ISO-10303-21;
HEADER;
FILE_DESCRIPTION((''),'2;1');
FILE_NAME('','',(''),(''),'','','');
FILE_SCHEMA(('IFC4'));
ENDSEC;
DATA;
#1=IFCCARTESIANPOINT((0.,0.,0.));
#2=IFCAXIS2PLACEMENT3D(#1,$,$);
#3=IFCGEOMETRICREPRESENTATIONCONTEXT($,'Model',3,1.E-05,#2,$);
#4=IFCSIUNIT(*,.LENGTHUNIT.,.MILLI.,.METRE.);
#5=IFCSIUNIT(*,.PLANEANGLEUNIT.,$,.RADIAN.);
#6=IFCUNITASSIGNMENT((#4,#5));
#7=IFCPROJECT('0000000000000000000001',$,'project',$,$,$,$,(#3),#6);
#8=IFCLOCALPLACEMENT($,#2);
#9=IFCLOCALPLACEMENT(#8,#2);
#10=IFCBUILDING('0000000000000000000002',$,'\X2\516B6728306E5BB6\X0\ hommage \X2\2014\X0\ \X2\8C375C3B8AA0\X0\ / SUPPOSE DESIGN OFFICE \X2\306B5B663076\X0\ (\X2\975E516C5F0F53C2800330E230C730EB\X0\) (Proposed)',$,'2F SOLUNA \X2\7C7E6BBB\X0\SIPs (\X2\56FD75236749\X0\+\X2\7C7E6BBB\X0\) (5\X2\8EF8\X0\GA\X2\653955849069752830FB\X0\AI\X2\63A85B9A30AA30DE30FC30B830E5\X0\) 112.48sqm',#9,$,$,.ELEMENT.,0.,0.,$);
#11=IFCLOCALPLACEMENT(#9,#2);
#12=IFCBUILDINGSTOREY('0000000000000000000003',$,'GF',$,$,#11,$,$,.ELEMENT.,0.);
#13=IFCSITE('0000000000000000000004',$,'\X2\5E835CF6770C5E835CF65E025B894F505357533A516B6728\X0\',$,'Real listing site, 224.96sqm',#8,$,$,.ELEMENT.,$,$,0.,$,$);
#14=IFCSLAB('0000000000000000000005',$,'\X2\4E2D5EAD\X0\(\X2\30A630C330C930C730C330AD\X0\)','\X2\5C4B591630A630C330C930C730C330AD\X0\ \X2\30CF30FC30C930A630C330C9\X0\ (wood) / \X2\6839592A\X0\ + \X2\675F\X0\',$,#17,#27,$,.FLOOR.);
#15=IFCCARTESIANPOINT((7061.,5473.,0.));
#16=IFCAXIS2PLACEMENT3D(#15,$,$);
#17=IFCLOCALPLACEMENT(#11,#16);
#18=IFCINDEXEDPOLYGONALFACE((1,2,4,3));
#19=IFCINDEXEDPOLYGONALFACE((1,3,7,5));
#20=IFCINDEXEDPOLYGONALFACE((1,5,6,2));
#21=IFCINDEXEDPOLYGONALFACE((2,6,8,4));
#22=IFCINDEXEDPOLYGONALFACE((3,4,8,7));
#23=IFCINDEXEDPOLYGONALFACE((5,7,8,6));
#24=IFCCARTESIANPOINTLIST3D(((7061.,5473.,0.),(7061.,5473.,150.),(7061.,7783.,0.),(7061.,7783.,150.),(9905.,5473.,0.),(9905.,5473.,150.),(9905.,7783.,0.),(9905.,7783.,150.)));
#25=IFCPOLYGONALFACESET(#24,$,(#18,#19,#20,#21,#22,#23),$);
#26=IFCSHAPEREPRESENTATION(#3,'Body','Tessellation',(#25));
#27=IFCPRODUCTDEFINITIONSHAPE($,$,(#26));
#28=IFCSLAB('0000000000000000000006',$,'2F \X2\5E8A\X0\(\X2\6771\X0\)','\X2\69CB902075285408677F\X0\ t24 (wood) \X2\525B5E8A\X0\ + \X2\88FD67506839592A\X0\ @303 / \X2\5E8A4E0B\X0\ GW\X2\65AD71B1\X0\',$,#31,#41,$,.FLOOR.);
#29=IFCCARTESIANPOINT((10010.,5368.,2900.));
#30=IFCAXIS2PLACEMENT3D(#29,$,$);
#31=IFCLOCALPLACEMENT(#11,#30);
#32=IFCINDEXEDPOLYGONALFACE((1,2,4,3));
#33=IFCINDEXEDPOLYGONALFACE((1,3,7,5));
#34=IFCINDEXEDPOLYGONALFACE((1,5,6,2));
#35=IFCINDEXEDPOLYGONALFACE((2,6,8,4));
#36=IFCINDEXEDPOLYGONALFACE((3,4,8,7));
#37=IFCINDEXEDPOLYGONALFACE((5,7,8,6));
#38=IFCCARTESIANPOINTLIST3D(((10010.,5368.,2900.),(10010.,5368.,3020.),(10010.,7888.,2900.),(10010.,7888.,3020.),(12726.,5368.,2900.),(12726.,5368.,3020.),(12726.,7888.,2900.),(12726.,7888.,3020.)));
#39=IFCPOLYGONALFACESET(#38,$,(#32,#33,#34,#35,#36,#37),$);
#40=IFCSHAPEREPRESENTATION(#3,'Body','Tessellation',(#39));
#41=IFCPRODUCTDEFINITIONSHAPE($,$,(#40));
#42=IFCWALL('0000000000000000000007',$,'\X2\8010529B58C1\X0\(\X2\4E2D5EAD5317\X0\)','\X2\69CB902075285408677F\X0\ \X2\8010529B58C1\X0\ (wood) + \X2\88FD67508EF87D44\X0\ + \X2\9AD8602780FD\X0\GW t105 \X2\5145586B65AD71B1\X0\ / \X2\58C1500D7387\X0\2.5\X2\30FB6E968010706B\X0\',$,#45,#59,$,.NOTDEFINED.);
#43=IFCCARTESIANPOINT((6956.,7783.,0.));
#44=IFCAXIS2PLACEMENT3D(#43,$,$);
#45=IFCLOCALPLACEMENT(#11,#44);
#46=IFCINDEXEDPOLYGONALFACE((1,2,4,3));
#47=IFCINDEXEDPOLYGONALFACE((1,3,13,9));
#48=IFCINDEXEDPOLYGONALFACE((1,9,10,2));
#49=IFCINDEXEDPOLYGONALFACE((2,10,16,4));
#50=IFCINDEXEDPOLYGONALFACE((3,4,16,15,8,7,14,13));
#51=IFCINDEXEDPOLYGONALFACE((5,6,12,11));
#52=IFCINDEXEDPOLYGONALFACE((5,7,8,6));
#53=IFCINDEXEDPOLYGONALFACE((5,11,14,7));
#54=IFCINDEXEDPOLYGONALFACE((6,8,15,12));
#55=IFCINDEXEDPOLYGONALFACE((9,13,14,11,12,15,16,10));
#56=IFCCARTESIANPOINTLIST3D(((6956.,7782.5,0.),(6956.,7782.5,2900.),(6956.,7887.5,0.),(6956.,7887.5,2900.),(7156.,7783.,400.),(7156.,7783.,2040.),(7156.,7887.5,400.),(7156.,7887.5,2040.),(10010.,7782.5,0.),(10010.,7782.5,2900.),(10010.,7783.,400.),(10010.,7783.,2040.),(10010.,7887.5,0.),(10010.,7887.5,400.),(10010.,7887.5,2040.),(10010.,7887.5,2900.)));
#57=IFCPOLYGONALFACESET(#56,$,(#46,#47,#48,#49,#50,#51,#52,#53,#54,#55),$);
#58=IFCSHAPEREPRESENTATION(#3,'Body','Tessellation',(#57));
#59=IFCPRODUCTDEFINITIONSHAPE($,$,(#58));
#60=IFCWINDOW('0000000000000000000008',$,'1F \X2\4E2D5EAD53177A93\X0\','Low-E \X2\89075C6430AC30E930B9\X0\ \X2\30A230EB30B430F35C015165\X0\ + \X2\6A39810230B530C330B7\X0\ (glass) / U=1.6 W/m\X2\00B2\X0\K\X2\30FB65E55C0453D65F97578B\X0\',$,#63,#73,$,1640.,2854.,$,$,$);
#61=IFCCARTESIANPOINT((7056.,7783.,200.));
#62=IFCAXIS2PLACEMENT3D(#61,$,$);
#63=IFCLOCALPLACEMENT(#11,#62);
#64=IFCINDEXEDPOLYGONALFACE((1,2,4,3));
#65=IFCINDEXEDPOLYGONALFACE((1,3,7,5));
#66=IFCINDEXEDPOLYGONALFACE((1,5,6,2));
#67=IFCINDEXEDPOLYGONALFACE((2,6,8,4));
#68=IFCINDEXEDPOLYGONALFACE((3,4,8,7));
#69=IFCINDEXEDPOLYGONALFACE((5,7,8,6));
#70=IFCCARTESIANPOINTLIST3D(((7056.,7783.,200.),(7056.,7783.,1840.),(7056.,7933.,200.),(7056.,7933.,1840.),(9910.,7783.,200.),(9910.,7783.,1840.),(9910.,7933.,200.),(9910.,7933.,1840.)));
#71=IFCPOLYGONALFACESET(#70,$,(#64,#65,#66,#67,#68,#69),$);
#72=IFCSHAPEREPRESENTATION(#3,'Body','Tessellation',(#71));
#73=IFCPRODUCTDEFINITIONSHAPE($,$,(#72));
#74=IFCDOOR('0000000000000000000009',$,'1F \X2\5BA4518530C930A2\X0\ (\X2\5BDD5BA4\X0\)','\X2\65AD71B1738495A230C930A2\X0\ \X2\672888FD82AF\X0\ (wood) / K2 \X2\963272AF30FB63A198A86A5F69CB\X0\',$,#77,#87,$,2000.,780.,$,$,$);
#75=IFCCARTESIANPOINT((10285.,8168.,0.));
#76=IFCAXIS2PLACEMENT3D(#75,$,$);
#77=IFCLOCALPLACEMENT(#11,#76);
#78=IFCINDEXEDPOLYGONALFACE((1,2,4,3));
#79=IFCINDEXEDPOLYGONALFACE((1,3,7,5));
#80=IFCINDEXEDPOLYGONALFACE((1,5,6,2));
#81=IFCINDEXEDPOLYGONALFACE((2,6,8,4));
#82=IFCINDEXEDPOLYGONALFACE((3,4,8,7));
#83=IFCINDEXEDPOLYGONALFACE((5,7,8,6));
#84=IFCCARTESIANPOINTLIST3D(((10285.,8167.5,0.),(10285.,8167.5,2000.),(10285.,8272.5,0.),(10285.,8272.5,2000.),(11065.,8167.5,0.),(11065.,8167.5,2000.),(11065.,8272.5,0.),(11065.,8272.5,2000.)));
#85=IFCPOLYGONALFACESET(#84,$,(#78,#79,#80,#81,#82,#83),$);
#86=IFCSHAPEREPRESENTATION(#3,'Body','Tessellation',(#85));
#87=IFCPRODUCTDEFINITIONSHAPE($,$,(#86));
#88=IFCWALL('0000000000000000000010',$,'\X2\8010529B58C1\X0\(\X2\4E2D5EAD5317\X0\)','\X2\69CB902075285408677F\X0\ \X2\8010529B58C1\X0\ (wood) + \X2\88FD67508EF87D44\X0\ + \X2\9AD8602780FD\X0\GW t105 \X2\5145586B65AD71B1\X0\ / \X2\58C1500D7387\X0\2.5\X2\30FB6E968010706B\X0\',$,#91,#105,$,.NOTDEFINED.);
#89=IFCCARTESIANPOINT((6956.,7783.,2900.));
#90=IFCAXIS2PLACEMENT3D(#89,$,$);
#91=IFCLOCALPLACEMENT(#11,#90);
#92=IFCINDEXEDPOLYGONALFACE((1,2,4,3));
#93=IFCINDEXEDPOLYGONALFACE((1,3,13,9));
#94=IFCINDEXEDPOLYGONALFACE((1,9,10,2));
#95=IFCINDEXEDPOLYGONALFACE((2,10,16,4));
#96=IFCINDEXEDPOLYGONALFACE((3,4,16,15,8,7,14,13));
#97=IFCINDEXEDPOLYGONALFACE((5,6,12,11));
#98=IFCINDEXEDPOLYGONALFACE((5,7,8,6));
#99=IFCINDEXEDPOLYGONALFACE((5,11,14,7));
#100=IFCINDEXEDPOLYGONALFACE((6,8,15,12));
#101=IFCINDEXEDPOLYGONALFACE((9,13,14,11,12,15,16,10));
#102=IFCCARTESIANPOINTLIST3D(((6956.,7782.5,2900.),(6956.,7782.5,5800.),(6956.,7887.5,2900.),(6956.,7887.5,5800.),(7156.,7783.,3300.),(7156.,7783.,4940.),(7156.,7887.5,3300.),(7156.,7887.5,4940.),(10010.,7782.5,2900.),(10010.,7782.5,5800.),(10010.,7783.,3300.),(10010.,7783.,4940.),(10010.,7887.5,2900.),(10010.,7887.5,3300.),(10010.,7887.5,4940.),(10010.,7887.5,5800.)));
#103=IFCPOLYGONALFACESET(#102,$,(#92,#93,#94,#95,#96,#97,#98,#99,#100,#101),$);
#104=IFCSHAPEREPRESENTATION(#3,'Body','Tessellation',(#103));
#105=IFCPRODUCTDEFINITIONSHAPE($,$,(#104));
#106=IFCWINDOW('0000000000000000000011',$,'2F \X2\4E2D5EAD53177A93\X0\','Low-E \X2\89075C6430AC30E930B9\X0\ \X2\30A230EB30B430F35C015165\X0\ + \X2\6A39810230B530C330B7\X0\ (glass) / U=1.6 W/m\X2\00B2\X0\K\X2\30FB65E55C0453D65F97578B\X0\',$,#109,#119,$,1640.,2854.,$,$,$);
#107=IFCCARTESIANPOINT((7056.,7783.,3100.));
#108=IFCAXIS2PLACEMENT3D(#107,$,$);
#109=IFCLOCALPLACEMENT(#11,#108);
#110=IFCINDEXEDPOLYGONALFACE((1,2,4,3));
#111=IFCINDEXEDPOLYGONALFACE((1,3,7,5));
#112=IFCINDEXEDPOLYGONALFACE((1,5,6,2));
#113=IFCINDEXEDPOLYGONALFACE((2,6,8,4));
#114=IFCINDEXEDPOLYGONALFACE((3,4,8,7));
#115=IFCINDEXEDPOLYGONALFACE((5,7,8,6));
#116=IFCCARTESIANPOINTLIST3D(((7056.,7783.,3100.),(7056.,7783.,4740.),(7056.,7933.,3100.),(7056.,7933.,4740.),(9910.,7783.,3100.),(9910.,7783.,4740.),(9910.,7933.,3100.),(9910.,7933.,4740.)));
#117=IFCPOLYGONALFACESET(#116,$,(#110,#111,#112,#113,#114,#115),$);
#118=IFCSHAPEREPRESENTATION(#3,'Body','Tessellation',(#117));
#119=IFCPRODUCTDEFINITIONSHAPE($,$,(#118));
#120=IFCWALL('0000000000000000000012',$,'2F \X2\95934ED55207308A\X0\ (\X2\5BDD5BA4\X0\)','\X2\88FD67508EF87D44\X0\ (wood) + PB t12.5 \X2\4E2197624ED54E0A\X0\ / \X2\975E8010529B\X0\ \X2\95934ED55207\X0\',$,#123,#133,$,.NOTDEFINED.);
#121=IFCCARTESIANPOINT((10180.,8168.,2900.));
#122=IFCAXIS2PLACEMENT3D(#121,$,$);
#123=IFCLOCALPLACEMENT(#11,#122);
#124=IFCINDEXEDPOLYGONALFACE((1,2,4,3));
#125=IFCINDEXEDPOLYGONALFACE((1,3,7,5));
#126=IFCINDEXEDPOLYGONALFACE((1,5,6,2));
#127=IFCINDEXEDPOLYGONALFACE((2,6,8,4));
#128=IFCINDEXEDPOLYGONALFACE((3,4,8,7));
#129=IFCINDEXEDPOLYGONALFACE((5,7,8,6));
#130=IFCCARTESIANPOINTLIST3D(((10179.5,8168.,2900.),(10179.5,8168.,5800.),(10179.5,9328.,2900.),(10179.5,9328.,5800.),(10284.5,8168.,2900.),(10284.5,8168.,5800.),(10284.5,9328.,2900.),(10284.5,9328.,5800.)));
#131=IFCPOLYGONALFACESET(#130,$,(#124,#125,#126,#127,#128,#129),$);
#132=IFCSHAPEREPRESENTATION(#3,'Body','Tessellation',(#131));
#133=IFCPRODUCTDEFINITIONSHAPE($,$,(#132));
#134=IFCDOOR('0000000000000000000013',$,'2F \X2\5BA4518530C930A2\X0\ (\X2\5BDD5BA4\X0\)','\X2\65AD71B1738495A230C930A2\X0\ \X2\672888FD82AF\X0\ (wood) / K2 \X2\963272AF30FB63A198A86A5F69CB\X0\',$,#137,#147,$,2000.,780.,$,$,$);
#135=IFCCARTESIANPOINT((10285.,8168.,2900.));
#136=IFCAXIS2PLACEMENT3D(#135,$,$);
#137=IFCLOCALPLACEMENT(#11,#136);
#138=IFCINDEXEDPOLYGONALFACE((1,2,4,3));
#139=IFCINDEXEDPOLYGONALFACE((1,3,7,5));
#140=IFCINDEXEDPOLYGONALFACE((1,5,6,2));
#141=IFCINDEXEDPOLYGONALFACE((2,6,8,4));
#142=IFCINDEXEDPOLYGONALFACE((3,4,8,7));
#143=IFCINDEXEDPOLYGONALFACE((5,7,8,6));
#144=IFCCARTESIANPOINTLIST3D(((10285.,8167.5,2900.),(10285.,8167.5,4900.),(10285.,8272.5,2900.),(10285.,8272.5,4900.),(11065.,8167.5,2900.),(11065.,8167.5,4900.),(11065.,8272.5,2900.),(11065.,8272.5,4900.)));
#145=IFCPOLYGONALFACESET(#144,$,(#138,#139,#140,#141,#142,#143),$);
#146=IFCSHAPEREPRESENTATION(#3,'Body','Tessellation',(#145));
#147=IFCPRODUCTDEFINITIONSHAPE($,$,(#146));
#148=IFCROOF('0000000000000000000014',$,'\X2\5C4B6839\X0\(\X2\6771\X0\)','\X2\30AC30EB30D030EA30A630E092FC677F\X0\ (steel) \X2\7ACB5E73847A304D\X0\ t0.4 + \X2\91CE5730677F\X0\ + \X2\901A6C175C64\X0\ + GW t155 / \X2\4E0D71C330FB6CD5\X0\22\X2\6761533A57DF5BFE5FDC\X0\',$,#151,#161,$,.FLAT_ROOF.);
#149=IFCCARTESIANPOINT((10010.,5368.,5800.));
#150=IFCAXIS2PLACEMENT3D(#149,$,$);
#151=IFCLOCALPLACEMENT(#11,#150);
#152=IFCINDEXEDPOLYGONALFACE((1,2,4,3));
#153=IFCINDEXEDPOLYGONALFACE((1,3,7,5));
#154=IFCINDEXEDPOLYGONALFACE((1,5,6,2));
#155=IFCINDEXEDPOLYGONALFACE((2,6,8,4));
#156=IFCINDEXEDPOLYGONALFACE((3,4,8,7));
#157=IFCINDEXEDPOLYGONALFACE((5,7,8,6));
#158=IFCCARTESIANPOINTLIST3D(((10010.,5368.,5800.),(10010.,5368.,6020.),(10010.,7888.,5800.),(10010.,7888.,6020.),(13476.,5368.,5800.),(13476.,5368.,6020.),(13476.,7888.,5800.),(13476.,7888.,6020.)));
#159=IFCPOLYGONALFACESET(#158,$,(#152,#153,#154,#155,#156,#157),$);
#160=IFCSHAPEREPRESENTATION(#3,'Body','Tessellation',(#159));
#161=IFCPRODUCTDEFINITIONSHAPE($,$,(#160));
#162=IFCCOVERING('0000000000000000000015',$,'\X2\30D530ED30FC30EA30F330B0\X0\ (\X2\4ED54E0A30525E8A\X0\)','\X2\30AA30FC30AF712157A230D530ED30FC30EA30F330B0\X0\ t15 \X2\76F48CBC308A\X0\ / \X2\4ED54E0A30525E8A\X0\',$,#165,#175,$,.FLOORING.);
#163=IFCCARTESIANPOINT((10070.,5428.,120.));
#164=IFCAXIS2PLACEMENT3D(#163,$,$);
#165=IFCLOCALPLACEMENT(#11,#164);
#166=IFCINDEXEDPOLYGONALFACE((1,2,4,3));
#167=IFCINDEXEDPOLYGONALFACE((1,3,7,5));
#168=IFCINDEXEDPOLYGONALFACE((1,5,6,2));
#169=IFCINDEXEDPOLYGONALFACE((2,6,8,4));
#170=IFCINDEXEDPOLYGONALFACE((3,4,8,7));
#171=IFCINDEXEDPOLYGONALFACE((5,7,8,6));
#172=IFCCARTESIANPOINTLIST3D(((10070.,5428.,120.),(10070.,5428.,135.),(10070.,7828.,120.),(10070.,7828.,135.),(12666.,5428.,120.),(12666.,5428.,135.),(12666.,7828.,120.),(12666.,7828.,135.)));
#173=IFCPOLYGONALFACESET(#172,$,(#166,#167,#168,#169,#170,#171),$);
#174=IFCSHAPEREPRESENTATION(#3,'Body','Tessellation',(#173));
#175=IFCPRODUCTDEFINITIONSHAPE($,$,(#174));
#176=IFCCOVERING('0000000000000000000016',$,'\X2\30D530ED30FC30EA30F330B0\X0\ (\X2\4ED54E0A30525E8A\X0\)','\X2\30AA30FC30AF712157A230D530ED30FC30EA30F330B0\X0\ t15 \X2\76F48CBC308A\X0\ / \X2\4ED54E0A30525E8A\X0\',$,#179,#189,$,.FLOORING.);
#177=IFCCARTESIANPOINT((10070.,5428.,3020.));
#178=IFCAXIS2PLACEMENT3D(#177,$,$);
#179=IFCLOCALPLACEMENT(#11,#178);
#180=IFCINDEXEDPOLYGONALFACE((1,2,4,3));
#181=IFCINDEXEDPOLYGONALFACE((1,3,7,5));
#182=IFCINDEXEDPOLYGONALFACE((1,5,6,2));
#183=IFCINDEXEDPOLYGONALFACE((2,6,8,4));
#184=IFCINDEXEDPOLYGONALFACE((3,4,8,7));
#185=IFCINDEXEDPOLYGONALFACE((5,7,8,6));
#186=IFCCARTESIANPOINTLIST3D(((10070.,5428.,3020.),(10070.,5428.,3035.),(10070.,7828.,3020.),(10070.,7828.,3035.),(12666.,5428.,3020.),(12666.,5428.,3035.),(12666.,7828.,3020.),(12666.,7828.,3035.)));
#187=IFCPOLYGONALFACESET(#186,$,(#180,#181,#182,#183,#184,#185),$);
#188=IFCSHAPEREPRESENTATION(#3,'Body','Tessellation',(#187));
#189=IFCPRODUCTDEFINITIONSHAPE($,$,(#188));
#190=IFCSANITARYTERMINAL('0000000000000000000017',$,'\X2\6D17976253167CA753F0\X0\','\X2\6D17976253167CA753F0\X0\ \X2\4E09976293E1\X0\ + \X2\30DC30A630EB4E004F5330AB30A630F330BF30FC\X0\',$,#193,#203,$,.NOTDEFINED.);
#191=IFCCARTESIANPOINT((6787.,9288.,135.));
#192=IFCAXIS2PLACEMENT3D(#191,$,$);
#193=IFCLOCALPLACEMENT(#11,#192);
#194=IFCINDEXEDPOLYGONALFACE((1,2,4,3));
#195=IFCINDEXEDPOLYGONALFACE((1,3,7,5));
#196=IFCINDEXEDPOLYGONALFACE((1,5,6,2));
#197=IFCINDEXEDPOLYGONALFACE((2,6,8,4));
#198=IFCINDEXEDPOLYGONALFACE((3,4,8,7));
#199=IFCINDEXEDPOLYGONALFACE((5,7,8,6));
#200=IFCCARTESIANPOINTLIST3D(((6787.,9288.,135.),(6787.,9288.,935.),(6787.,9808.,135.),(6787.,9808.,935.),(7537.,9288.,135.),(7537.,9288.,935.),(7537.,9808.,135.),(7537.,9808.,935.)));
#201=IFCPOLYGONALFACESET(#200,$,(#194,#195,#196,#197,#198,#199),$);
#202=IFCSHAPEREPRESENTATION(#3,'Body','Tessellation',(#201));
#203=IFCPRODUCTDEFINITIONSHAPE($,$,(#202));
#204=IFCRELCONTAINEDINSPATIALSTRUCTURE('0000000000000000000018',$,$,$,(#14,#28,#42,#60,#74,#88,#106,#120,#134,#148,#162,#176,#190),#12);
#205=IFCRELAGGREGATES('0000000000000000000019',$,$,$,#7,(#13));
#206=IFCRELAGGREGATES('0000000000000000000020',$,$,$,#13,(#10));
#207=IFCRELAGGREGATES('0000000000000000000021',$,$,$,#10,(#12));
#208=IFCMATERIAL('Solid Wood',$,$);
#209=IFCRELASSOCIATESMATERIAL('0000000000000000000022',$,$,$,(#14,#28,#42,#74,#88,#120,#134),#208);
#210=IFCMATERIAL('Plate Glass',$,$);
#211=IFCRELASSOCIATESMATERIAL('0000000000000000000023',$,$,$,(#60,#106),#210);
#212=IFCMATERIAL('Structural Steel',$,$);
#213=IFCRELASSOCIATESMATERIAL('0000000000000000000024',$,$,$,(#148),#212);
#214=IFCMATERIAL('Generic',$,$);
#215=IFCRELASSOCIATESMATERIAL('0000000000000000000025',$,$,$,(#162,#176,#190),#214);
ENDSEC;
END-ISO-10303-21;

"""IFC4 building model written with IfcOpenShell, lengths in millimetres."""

from ifc_helpers import new_model, si_unit, frame, frame_2d, origin, place, context, project, spatial, rectangle, extrude, material, element, fill, save


model = new_model("IFC4")

# Units and contexts
model_context = context("Model", 3, precision=1e-05, world=origin())
ifc_project = project(units=[si_unit("LENGTHUNIT", "METRE", prefix="MILLI"), si_unit("PLANEANGLEUNIT", "RADIAN")], contexts=[model_context])

# Site, building, storey
site_placement = place(None, origin())
site = spatial("IfcSite", under=ifc_project, at=site_placement, Name="広島県広島市安佐南区八木", ObjectType="Real listing site, 224.96sqm", CompositionType="ELEMENT", RefElevation=0.0)
building_placement = place(site_placement, origin())
building = spatial("IfcBuilding", under=site, at=building_placement, Name="八木の家 hommage — 谷尻誠 / SUPPOSE DESIGN OFFICE に学ぶ (非公式参考モデル) (Proposed)", ObjectType="2F SOLUNA 籾殻SIPs (国産杉+籾殻) (5軸GA改善適用・AI推定オマージュ) 112.48sqm", CompositionType="ELEMENT", ElevationOfRefHeight=0.0, ElevationOfTerrain=0.0)
storey_placement = place(building_placement, origin())
storey = spatial("IfcBuildingStorey", under=building, at=storey_placement, Name="GF", CompositionType="ELEMENT", Elevation=0.0)

# Slabs
ifc_material_1 = material(Name="Solid Wood")
slab_1_placement = place(storey_placement, frame((7061.0, 5473.0, 0.0)))
element("IfcSlab", 1, at=slab_1_placement, inside=storey, material=ifc_material_1, Name="中庭(ウッドデッキ)", Description="屋外ウッドデッキ ハードウッド (wood) / 根太 + 束", PredefinedType="FLOOR", context=model_context, shape_type="SweptSolid", body=[
    extrude(rectangle(XDim=2844.0, YDim=2310.0, at=frame_2d((1422.0, 1155.0))), frame((7061.0, 5473.0, 0.0)), (0.0, 0.0, 1.0), 150.0),
])
slab_2_placement = place(storey_placement, frame((10010.0, 5368.0, 2900.0)))
element("IfcSlab", 2, at=slab_2_placement, inside=storey, material=ifc_material_1, Name="2F 床(東)", Description="構造用合板 t24 (wood) 剛床 + 製材根太 @303 / 床下 GW断熱", PredefinedType="FLOOR", context=model_context, shape_type="SweptSolid", body=[
    extrude(rectangle(XDim=2716.0, YDim=2520.0, at=frame_2d((1358.0, 1260.0))), frame((10010.0, 5368.0, 2900.0)), (0.0, 0.0, 1.0), 120.0),
])

# Wall, opening, window
wall_1_placement = place(storey_placement, frame((6956.0, 7783.0, 0.0)))
wall_1 = element("IfcWall", 3, at=wall_1_placement, inside=storey, material=ifc_material_1, Name="耐力壁(中庭北)", Description="構造用合板 耐力壁 (wood) + 製材軸組 + 高性能GW t105 充填断熱 / 壁倍率2.5・準耐火", PredefinedType="NOTDEFINED", context=model_context, shape_type="SweptSolid", body=[
    extrude(rectangle(XDim=3054.0, YDim=105.0, at=frame_2d((1527.0, 52.0))), frame((6956.0, 7783.0, 0.0)), (0.0, 0.0, 1.0), 2900.0),
])
opening_1_placement = place(storey_placement, frame((7056.0, 7783.0, 200.0)))
opening_1 = element("IfcOpeningElement", 4, at=opening_1_placement, cuts=wall_1, PredefinedType="NOTDEFINED", context=model_context, shape_type="SweptSolid", body=[
    extrude(rectangle(XDim=2854.0, YDim=150.0, at=frame_2d((1427.0, 75.0))), frame((7056.0, 7783.0, 200.0)), (0.0, 0.0, 1.0), 1640.0),
])
ifc_material_2 = material(Name="Plate Glass")
window_1_placement = place(storey_placement, frame((7056.0, 7783.0, 200.0)))
window_1 = element("IfcWindow", 5, at=window_1_placement, inside=storey, material=ifc_material_2, Name="1F 中庭北窓", Description="Low-E 複層ガラス アルゴン封入 + 樹脂サッシ (glass) / U=1.6 W/m²K・日射取得型", OverallHeight=1640.0, OverallWidth=2854.0, context=model_context, shape_type="SweptSolid", body=[
    extrude(rectangle(XDim=2854.0, YDim=150.0, at=frame_2d((1427.0, 75.0))), frame((7056.0, 7783.0, 200.0)), (0.0, 0.0, 1.0), 1640.0),
])
fill(opening_1, window_1)

# Door
door_1_placement = place(storey_placement, frame((10285.0, 8168.0, 0.0)))
element("IfcDoor", 6, at=door_1_placement, inside=storey, material=ifc_material_1, Name="1F 室内ドア (寝室)", Description="断熱玄関ドア 木製芯 (wood) / K2 防犯・採風機構", OverallHeight=2000.0, OverallWidth=780.0, context=model_context, shape_type="SweptSolid", body=[
    extrude(rectangle(XDim=780.0, YDim=105.0, at=frame_2d((390.0, 52.0))), frame((10285.0, 8168.0, 0.0)), (0.0, 0.0, 1.0), 2000.0),
])

# Wall, opening, window
wall_2_placement = place(storey_placement, frame((6956.0, 7783.0, 2900.0)))
wall_2 = element("IfcWall", 7, at=wall_2_placement, inside=storey, material=ifc_material_1, Name="耐力壁(中庭北)", Description="構造用合板 耐力壁 (wood) + 製材軸組 + 高性能GW t105 充填断熱 / 壁倍率2.5・準耐火", PredefinedType="NOTDEFINED", context=model_context, shape_type="SweptSolid", body=[
    extrude(rectangle(XDim=3054.0, YDim=105.0, at=frame_2d((1527.0, 52.0))), frame((6956.0, 7783.0, 2900.0)), (0.0, 0.0, 1.0), 2900.0),
])
opening_2_placement = place(storey_placement, frame((7056.0, 7783.0, 3100.0)))
opening_2 = element("IfcOpeningElement", 8, at=opening_2_placement, cuts=wall_2, PredefinedType="NOTDEFINED", context=model_context, shape_type="SweptSolid", body=[
    extrude(rectangle(XDim=2854.0, YDim=150.0, at=frame_2d((1427.0, 75.0))), frame((7056.0, 7783.0, 3100.0)), (0.0, 0.0, 1.0), 1640.0),
])
window_2_placement = place(storey_placement, frame((7056.0, 7783.0, 3100.0)))
window_2 = element("IfcWindow", 9, at=window_2_placement, inside=storey, material=ifc_material_2, Name="2F 中庭北窓", Description="Low-E 複層ガラス アルゴン封入 + 樹脂サッシ (glass) / U=1.6 W/m²K・日射取得型", OverallHeight=1640.0, OverallWidth=2854.0, context=model_context, shape_type="SweptSolid", body=[
    extrude(rectangle(XDim=2854.0, YDim=150.0, at=frame_2d((1427.0, 75.0))), frame((7056.0, 7783.0, 3100.0)), (0.0, 0.0, 1.0), 1640.0),
])
fill(opening_2, window_2)

# Wall
wall_3_placement = place(storey_placement, frame((10180.0, 8168.0, 2900.0)))
element("IfcWall", 10, at=wall_3_placement, inside=storey, material=ifc_material_1, Name="2F 間仕切り (寝室)", Description="製材軸組 (wood) + PB t12.5 両面仕上 / 非耐力 間仕切", PredefinedType="NOTDEFINED", context=model_context, shape_type="SweptSolid", body=[
    extrude(rectangle(XDim=105.0, YDim=1160.0, at=frame_2d((52.0, 580.0))), frame((10180.0, 8168.0, 2900.0)), (0.0, 0.0, 1.0), 2900.0),
])

# Door
door_2_placement = place(storey_placement, frame((10285.0, 8168.0, 2900.0)))
element("IfcDoor", 11, at=door_2_placement, inside=storey, material=ifc_material_1, Name="2F 室内ドア (寝室)", Description="断熱玄関ドア 木製芯 (wood) / K2 防犯・採風機構", OverallHeight=2000.0, OverallWidth=780.0, context=model_context, shape_type="SweptSolid", body=[
    extrude(rectangle(XDim=780.0, YDim=105.0, at=frame_2d((390.0, 52.0))), frame((10285.0, 8168.0, 2900.0)), (0.0, 0.0, 1.0), 2000.0),
])

# Roof
ifc_material_3 = material(Name="Structural Steel")
for number, where, name in (
    (12, (10010.0, 5368.0, 5800.0), "屋根(東)"),
):
    element("IfcRoof", number, at=place(storey_placement, frame(where)), inside=storey, material=ifc_material_3, Name=name, Description="ガルバリウム鋼板 (steel) 立平葺き t0.4 + 野地板 + 通気層 + GW t155 / 不燃・法22条区域対応", PredefinedType="FLAT_ROOF", context=model_context, shape_type="SweptSolid", body=[
        extrude(rectangle(XDim=3466.0, YDim=2520.0, at=frame_2d((1733.0, 1260.0))), frame((10010.0, 5368.0, 5800.0)), (0.0, 0.0, 1.0), 220.0),
    ])

# Coverings
ifc_material_4 = material(Name="Generic")
covering_1_placement = place(storey_placement, frame((10070.0, 5428.0, 120.0)))
element("IfcCovering", 13, at=covering_1_placement, inside=storey, material=ifc_material_4, Name="フローリング (仕上げ床)", Description="オーク無垢フローリング t15 直貼り / 仕上げ床", PredefinedType="FLOORING", context=model_context, shape_type="SweptSolid", body=[
    extrude(rectangle(XDim=2596.0, YDim=2400.0, at=frame_2d((1298.0, 1200.0))), frame((10070.0, 5428.0, 120.0)), (0.0, 0.0, 1.0), 15.0),
])
covering_2_placement = place(storey_placement, frame((10070.0, 5428.0, 3020.0)))
element("IfcCovering", 14, at=covering_2_placement, inside=storey, material=ifc_material_4, Name="フローリング (仕上げ床)", Description="オーク無垢フローリング t15 直貼り / 仕上げ床", PredefinedType="FLOORING", context=model_context, shape_type="SweptSolid", body=[
    extrude(rectangle(XDim=2596.0, YDim=2400.0, at=frame_2d((1298.0, 1200.0))), frame((10070.0, 5428.0, 3020.0)), (0.0, 0.0, 1.0), 15.0),
])

# Sanitary terminal
sanitary_terminal_1_placement = place(storey_placement, frame((6787.0, 9288.0, 135.0)))
element("IfcSanitaryTerminal", 15, at=sanitary_terminal_1_placement, inside=storey, material=ifc_material_4, Name="洗面化粧台", Description="洗面化粧台 三面鏡 + ボウル一体カウンター", PredefinedType="NOTDEFINED", context=model_context, shape_type="SweptSolid", body=[
    extrude(rectangle(XDim=750.0, YDim=520.0, at=frame_2d((375.0, 260.0))), frame((6787.0, 9288.0, 135.0)), (0.0, 0.0, 1.0), 800.0),
])

save(model, "model.ifc")
